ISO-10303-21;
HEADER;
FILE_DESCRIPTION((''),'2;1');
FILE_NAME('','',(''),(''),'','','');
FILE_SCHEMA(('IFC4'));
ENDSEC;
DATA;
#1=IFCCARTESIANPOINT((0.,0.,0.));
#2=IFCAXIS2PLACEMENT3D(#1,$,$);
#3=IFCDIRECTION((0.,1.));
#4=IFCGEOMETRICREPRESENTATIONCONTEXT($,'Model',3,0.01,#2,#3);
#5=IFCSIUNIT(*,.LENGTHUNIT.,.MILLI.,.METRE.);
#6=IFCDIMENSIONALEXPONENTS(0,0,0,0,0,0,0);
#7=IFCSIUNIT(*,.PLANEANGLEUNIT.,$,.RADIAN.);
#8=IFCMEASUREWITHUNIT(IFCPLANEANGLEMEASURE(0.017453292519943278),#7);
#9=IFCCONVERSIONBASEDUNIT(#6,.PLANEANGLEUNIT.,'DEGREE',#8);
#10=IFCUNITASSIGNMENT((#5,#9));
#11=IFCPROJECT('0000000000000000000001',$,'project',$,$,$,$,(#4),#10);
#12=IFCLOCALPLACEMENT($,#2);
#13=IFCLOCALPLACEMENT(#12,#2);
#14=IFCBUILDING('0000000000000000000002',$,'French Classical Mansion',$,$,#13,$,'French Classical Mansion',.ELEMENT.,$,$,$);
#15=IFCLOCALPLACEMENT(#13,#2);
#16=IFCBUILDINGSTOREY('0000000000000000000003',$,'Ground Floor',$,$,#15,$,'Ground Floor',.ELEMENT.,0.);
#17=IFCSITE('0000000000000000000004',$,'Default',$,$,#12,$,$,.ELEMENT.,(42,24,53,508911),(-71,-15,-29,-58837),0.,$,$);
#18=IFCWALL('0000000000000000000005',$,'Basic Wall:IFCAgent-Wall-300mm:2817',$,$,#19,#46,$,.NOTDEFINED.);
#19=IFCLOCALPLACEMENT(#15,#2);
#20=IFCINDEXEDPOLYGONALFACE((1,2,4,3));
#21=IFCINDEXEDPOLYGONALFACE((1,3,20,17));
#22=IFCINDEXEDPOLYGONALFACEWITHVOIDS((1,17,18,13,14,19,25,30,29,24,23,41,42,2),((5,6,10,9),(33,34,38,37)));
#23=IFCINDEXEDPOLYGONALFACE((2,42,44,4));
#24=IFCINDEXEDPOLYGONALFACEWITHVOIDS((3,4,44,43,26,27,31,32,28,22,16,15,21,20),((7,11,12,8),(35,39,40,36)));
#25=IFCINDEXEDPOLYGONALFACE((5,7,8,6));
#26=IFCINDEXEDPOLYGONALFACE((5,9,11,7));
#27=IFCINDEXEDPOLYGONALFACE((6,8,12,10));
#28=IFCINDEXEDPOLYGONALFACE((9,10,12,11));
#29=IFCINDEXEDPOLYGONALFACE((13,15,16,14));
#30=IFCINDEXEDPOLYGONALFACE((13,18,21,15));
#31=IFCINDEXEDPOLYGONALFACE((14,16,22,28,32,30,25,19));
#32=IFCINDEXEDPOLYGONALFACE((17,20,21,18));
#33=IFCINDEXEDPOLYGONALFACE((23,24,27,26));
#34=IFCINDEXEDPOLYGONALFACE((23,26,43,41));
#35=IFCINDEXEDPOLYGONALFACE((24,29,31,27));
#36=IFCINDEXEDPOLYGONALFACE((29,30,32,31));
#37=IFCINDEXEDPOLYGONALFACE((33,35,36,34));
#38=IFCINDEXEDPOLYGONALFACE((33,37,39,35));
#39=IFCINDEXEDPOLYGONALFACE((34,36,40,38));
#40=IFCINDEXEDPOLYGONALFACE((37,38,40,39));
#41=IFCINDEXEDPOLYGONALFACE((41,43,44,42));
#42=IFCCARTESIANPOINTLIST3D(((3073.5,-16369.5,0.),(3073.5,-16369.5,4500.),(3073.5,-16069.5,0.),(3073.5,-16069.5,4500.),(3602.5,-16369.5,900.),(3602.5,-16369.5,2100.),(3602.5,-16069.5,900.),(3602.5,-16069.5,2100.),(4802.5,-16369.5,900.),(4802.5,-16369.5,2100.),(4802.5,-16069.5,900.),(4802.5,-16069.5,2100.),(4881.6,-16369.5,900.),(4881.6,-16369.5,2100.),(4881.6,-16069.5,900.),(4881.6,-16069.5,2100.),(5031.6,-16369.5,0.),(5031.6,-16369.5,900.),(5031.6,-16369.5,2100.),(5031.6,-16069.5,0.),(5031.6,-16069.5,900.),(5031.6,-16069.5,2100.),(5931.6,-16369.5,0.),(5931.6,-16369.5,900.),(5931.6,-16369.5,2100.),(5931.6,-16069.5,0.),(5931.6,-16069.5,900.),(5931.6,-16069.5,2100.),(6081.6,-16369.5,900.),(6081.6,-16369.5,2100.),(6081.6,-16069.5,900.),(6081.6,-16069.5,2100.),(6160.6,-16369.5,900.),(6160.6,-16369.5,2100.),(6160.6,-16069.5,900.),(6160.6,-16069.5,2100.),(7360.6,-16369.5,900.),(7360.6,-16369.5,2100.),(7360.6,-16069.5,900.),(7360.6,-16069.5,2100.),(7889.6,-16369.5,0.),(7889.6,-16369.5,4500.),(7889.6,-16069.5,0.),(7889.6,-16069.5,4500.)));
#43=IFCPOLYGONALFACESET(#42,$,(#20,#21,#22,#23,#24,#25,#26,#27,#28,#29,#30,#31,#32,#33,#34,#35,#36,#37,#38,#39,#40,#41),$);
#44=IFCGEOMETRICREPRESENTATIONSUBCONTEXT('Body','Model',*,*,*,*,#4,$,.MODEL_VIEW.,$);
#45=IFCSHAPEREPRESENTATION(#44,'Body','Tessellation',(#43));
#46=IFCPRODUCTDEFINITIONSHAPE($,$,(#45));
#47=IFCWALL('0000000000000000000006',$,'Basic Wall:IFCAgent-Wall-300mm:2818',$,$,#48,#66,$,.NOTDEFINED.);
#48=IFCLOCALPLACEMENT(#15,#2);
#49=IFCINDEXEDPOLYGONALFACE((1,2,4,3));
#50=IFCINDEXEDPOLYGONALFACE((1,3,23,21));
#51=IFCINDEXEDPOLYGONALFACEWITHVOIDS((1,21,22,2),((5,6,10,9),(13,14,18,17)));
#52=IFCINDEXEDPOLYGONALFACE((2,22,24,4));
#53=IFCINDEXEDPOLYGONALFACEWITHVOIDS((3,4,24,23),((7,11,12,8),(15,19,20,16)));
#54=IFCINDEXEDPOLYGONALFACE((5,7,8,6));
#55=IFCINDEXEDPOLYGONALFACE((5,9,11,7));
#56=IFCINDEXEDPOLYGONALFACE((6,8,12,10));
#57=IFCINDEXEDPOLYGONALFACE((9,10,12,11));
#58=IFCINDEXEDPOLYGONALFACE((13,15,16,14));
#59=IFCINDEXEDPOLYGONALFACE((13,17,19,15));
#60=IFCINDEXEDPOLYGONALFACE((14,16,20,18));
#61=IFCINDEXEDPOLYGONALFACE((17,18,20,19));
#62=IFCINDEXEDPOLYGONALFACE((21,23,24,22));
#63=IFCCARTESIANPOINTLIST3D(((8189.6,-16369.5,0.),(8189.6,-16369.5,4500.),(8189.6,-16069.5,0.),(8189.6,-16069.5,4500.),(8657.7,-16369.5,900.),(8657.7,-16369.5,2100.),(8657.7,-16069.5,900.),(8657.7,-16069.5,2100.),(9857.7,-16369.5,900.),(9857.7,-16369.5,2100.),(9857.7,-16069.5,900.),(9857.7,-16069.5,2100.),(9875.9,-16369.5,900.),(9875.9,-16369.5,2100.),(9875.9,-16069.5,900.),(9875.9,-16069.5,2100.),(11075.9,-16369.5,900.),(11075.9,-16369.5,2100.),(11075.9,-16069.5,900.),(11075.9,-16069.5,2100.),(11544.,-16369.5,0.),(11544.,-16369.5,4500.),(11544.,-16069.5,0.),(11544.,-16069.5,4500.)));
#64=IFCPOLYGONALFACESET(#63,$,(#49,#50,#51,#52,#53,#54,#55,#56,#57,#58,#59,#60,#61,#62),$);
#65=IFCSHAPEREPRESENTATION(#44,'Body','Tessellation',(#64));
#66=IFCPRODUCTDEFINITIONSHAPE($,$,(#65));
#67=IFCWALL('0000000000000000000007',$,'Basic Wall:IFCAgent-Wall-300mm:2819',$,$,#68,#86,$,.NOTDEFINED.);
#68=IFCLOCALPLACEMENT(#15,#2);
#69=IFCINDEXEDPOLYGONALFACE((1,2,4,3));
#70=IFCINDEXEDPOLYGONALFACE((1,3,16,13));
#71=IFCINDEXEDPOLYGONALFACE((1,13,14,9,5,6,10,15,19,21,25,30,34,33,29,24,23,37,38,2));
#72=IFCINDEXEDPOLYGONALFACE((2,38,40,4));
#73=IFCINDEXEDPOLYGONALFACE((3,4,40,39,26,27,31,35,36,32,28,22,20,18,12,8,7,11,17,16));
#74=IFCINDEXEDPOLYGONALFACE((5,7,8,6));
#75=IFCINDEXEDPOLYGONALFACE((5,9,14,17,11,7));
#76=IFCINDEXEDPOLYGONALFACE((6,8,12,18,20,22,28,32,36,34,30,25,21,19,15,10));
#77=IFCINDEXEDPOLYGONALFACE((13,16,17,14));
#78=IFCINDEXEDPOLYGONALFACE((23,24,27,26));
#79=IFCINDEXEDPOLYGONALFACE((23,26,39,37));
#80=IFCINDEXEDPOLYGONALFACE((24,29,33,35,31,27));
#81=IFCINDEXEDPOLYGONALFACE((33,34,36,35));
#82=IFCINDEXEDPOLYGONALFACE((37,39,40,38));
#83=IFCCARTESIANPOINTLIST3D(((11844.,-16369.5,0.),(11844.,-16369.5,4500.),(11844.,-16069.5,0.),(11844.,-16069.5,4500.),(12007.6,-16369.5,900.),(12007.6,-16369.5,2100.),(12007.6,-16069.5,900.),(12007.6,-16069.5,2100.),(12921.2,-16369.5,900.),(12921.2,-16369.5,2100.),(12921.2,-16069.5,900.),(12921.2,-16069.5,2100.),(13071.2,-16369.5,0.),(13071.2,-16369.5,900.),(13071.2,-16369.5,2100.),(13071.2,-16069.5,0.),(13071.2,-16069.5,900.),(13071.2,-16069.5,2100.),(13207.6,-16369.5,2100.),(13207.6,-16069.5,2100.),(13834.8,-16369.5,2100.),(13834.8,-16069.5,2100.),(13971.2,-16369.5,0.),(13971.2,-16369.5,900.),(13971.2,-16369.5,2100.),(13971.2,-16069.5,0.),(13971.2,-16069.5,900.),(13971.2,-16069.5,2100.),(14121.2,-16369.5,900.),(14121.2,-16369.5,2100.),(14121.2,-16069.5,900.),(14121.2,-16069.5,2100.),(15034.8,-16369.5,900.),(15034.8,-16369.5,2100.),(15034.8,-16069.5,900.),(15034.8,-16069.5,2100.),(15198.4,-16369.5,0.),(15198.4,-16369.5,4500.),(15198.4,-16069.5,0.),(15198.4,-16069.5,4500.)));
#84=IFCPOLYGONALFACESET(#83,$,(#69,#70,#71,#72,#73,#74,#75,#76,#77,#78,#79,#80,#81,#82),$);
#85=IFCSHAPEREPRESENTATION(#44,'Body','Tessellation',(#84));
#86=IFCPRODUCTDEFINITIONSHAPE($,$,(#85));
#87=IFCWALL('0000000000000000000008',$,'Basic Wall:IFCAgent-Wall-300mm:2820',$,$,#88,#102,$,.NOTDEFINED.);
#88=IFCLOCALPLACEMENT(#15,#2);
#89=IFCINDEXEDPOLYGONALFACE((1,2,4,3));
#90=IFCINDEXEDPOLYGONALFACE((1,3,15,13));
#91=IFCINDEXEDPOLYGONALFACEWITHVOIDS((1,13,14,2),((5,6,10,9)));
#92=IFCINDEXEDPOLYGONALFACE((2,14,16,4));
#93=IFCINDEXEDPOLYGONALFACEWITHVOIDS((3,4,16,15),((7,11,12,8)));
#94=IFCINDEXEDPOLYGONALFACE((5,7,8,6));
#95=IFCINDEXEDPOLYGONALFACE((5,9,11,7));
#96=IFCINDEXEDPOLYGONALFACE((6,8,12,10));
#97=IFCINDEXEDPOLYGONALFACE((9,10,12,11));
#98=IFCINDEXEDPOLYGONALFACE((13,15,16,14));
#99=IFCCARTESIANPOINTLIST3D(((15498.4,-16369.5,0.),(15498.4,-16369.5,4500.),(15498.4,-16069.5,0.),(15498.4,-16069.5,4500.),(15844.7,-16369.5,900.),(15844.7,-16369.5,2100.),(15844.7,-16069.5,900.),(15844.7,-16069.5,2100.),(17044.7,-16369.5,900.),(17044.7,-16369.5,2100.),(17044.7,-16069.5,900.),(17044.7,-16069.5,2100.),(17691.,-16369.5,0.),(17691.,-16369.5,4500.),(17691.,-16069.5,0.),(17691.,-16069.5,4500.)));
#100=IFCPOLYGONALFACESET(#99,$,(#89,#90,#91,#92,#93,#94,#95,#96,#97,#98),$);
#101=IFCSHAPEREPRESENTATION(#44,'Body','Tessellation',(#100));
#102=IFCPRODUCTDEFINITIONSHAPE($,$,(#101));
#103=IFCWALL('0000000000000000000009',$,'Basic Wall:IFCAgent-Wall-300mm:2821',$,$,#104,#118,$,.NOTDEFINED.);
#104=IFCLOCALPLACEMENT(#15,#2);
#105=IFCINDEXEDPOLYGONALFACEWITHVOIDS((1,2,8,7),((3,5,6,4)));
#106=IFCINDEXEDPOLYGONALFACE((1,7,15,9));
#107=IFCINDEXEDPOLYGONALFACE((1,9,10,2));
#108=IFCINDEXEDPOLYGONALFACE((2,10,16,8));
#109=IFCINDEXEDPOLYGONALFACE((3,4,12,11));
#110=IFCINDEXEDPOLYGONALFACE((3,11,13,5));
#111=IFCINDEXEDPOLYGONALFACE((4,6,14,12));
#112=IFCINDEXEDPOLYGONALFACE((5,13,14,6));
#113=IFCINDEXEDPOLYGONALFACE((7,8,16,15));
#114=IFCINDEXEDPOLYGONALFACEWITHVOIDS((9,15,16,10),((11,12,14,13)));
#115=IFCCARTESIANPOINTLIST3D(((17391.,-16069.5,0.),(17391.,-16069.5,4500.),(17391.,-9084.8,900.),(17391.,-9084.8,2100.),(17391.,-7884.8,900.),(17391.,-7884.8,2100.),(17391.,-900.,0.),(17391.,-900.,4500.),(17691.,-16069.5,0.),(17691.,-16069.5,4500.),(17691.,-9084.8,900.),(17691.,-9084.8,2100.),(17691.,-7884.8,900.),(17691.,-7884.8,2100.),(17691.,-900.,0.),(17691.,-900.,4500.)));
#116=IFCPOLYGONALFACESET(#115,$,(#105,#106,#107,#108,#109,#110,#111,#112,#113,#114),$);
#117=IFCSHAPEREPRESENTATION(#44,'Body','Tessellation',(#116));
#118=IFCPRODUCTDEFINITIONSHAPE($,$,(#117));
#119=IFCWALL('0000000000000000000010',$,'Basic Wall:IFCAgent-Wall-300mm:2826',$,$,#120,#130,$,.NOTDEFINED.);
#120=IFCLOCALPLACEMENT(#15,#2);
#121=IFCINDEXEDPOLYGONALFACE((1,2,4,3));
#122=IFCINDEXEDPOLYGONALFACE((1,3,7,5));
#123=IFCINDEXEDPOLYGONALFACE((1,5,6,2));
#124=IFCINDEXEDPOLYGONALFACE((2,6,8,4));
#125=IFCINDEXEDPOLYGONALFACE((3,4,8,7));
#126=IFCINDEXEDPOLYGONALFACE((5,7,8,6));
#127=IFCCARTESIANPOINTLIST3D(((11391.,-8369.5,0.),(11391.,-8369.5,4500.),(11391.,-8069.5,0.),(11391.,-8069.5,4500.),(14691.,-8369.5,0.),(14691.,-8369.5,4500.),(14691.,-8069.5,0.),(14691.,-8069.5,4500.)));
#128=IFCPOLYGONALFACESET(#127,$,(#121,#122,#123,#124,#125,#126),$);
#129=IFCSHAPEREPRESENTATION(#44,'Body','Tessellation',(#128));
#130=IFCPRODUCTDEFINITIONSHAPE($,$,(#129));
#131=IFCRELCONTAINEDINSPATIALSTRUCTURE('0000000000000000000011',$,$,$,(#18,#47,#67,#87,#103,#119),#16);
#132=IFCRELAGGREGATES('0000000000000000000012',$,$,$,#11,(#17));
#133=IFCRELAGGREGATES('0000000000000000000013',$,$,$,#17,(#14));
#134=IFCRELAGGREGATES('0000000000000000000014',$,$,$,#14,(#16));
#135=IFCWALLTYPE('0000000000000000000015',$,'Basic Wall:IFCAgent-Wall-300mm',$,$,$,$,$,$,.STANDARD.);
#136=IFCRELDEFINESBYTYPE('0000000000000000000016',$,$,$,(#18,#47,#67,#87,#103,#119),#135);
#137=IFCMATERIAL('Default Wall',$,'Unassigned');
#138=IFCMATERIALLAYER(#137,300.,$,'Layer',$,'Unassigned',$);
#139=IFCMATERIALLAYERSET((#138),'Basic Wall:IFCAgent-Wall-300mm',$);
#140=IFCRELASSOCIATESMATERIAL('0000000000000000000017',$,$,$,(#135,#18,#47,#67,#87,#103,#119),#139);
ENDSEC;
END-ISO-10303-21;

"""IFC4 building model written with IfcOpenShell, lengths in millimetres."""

from ifc_helpers import new_model, entity, si_unit, converted_unit, direction, frame, frame_2d, origin, place, context, subcontext, project, spatial, rectangle, extrude, material, layer, layer_set, layer_usage, type_object, element, save


model = new_model("IFC4")

# Units and contexts
model_context = context("Model", 3, precision=0.01, world=origin(), true_north=direction((0.0, 1.0)))
body_context = subcontext(model_context, "Body", "Model", "MODEL_VIEW")
ifc_project = project(units=[si_unit("LENGTHUNIT", "METRE", prefix="MILLI"), converted_unit("PLANEANGLEUNIT", "DEGREE", entity("IfcPlaneAngleMeasure", 0.017453292519943278), si_unit("PLANEANGLEUNIT", "RADIAN"), dimensions=[0, 0, 0, 0, 0, 0, 0])], contexts=[model_context])

# Site, building, storey
site_placement = place(None, origin())
site = spatial("IfcSite", under=ifc_project, at=site_placement, Name="Default", CompositionType="ELEMENT", RefLatitude=(42, 24, 53, 508911), RefLongitude=(-71, -15, -29, -58837), RefElevation=0.0)
building_placement = place(site_placement, origin())
building = spatial("IfcBuilding", under=site, at=building_placement, Name="French Classical Mansion", LongName="French Classical Mansion", CompositionType="ELEMENT")
storey_placement = place(building_placement, origin())
storey = spatial("IfcBuildingStorey", under=building, at=storey_placement, Name="Ground Floor", LongName="Ground Floor", CompositionType="ELEMENT", Elevation=0.0)

# Shared definitions
ifc_material = material(Name="Default Wall", Category="Unassigned")
ifc_layer = layer(ifc_material, 300.0, Name="Layer", Category="Unassigned")
ifc_layer_set = layer_set([ifc_layer], Name="Basic Wall:IFCAgent-Wall-300mm")
wall_type = type_object("IfcWallType", Name="Basic Wall:IFCAgent-Wall-300mm", PredefinedType="STANDARD", material=ifc_layer_set)

# Walls, openings
ifc_layer_usage_1 = layer_usage(ifc_layer_set, "AXIS2", "NEGATIVE", 150.0)
wall_1_placement = place(storey_placement, frame((3073.5, -16219.5, 0.0)))
wall_1 = element("IfcWall", 1, at=wall_1_placement, inside=storey, type_object=wall_type, material=ifc_layer_usage_1, Name="Basic Wall:IFCAgent-Wall-300mm:2817", PredefinedType="NOTDEFINED", context=body_context, shape_type="SweptSolid", body=[
    extrude(rectangle(XDim=4816.1, YDim=300.0, at=frame_2d((2408.1, 0.0), x_axis=(-1.0, 0.0))), origin(), (0.0, 0.0, 1.0), 4500.0),
])
opening_1_placement = place(wall_1_placement, origin())
element("IfcOpeningElement", 2, at=opening_1_placement, cuts=wall_1, PredefinedType="OPENING", context=body_context, shape_type="SweptSolid", body=[
    extrude(rectangle(XDim=2100.0, YDim=900.0, at=frame_2d((0.0, 0.0), x_axis=(1.0, 0.0))), frame((2408.1, -150.0, 1050.0), z_axis=(0.0, 1.0, 0.0), x_axis=(0.0, 0.0, -1.0)), (0.0, 0.0, 1.0), 300.0),
])
opening_2_placement = place(wall_1_placement, origin())
element("IfcOpeningElement", 3, at=opening_2_placement, cuts=wall_1, PredefinedType="OPENING", context=body_context, shape_type="SweptSolid", body=[
    extrude(rectangle(XDim=2100.0, YDim=900.0, at=frame_2d((0.0, 0.0), x_axis=(1.0, 0.0))), frame((2408.1, -150.0, 1050.0), z_axis=(0.0, 1.0, 0.0), x_axis=(0.0, 0.0, -1.0)), (0.0, 0.0, 1.0), 300.0),
])
opening_3_placement = place(wall_1_placement, origin())
element("IfcOpeningElement", 4, at=opening_3_placement, cuts=wall_1, PredefinedType="OPENING", context=body_context, shape_type="SweptSolid", body=[
    extrude(rectangle(XDim=1200.0, YDim=1200.0, at=frame_2d((0.0, 0.0), x_axis=(1.0, 0.0))), frame((1129.0, -150.0, 1500.0), z_axis=(0.0, 1.0, 0.0), x_axis=(0.0, 0.0, -1.0)), (0.0, 0.0, 1.0), 300.0),
])
opening_4_placement = place(wall_1_placement, origin())
element("IfcOpeningElement", 5, at=opening_4_placement, cuts=wall_1, PredefinedType="OPENING", context=body_context, shape_type="SweptSolid", body=[
    extrude(rectangle(XDim=1200.0, YDim=1200.0, at=frame_2d((0.0, 0.0), x_axis=(1.0, 0.0))), frame((2408.1, -150.0, 1500.0), z_axis=(0.0, 1.0, 0.0), x_axis=(0.0, 0.0, -1.0)), (0.0, 0.0, 1.0), 300.0),
])
opening_5_placement = place(wall_1_placement, origin())
element("IfcOpeningElement", 6, at=opening_5_placement, cuts=wall_1, PredefinedType="OPENING", context=body_context, shape_type="SweptSolid", body=[
    extrude(rectangle(XDim=1200.0, YDim=1200.0, at=frame_2d((0.0, 0.0), x_axis=(1.0, 0.0))), frame((3687.1, -150.0, 1500.0), z_axis=(0.0, 1.0, 0.0), x_axis=(0.0, 0.0, -1.0)), (0.0, 0.0, 1.0), 300.0),
])
ifc_layer_usage_2 = layer_usage(ifc_layer_set, "AXIS2", "NEGATIVE", 150.0)
wall_2_placement = place(storey_placement, frame((8189.6, -16219.5, 0.0)))
wall_2 = element("IfcWall", 7, at=wall_2_placement, inside=storey, type_object=wall_type, material=ifc_layer_usage_2, Name="Basic Wall:IFCAgent-Wall-300mm:2818", PredefinedType="NOTDEFINED", context=body_context, shape_type="SweptSolid", body=[
    extrude(rectangle(XDim=3354.4, YDim=300.0, at=frame_2d((1677.2, 0.0), x_axis=(-1.0, 0.0))), origin(), (0.0, 0.0, 1.0), 4500.0),
])
opening_6_placement = place(wall_2_placement, origin())
element("IfcOpeningElement", 8, at=opening_6_placement, cuts=wall_2, PredefinedType="OPENING", context=body_context, shape_type="SweptSolid", body=[
    extrude(rectangle(XDim=1200.0, YDim=1200.0, at=frame_2d((0.0, 0.0), x_axis=(1.0, 0.0))), frame((1068.1, -150.0, 1500.0), z_axis=(0.0, 1.0, 0.0), x_axis=(0.0, 0.0, -1.0)), (0.0, 0.0, 1.0), 300.0),
])
opening_7_placement = place(wall_2_placement, origin())
element("IfcOpeningElement", 9, at=opening_7_placement, cuts=wall_2, PredefinedType="OPENING", context=body_context, shape_type="SweptSolid", body=[
    extrude(rectangle(XDim=1200.0, YDim=1200.0, at=frame_2d((0.0, 0.0), x_axis=(1.0, 0.0))), frame((2286.2, -150.0, 1500.0), z_axis=(0.0, 1.0, 0.0), x_axis=(0.0, 0.0, -1.0)), (0.0, 0.0, 1.0), 300.0),
])
ifc_layer_usage_3 = layer_usage(ifc_layer_set, "AXIS2", "NEGATIVE", 150.0)
wall_3_placement = place(storey_placement, frame((11844.0, -16219.5, 0.0)))
wall_3 = element("IfcWall", 10, at=wall_3_placement, inside=storey, type_object=wall_type, material=ifc_layer_usage_3, Name="Basic Wall:IFCAgent-Wall-300mm:2819", PredefinedType="NOTDEFINED", context=body_context, shape_type="SweptSolid", body=[
    extrude(rectangle(XDim=3354.4, YDim=300.0, at=frame_2d((1677.2, 0.0), x_axis=(-1.0, 0.0))), origin(), (0.0, 0.0, 1.0), 4500.0),
])
opening_8_placement = place(wall_3_placement, origin())
element("IfcOpeningElement", 11, at=opening_8_placement, cuts=wall_3, PredefinedType="OPENING", context=body_context, shape_type="SweptSolid", body=[
    extrude(rectangle(XDim=2100.0, YDim=900.0, at=frame_2d((0.0, 0.0), x_axis=(1.0, 0.0))), frame((1677.2, -150.0, 1050.0), z_axis=(0.0, 1.0, 0.0), x_axis=(0.0, 0.0, -1.0)), (0.0, 0.0, 1.0), 300.0),
])
opening_9_placement = place(wall_3_placement, origin())
element("IfcOpeningElement", 12, at=opening_9_placement, cuts=wall_3, PredefinedType="OPENING", context=body_context, shape_type="SweptSolid", body=[
    extrude(rectangle(XDim=1200.0, YDim=1200.0, at=frame_2d((0.0, 0.0), x_axis=(1.0, 0.0))), frame((763.6, -150.0, 1500.0), z_axis=(0.0, 1.0, 0.0), x_axis=(0.0, 0.0, -1.0)), (0.0, 0.0, 1.0), 300.0),
])
opening_10_placement = place(wall_3_placement, origin())
element("IfcOpeningElement", 13, at=opening_10_placement, cuts=wall_3, PredefinedType="OPENING", context=body_context, shape_type="SweptSolid", body=[
    extrude(rectangle(XDim=1200.0, YDim=1200.0, at=frame_2d((0.0, 0.0), x_axis=(1.0, 0.0))), frame((1677.2, -150.0, 1500.0), z_axis=(0.0, 1.0, 0.0), x_axis=(0.0, 0.0, -1.0)), (0.0, 0.0, 1.0), 300.0),
])
opening_11_placement = place(wall_3_placement, origin())
element("IfcOpeningElement", 14, at=opening_11_placement, cuts=wall_3, PredefinedType="OPENING", context=body_context, shape_type="SweptSolid", body=[
    extrude(rectangle(XDim=1200.0, YDim=1200.0, at=frame_2d((0.0, 0.0), x_axis=(1.0, 0.0))), frame((2590.8, -150.0, 1500.0), z_axis=(0.0, 1.0, 0.0), x_axis=(0.0, 0.0, -1.0)), (0.0, 0.0, 1.0), 300.0),
])

# Walls, openings
ifc_layer_usage_4 = layer_usage(ifc_layer_set, "AXIS2", "NEGATIVE", 150.0)
wall_4_placement = place(storey_placement, frame((15498.4, -16219.5, 0.0)))
wall_4 = element("IfcWall", 15, at=wall_4_placement, inside=storey, type_object=wall_type, material=ifc_layer_usage_4, Name="Basic Wall:IFCAgent-Wall-300mm:2820", PredefinedType="NOTDEFINED", context=body_context, shape_type="SweptSolid", body=[
    extrude(rectangle(XDim=2192.6, YDim=300.0, at=frame_2d((1096.3, 0.0), x_axis=(-1.0, 0.0))), origin(), (0.0, 0.0, 1.0), 4500.0),
])
opening_12_placement = place(wall_4_placement, origin())
element("IfcOpeningElement", 16, at=opening_12_placement, cuts=wall_4, PredefinedType="OPENING", context=body_context, shape_type="SweptSolid", body=[
    extrude(rectangle(XDim=1200.0, YDim=1200.0, at=frame_2d((0.0, 0.0), x_axis=(1.0, 0.0))), frame((946.3, -150.0, 1500.0), z_axis=(0.0, 1.0, 0.0), x_axis=(0.0, 0.0, -1.0)), (0.0, 0.0, 1.0), 300.0),
])
ifc_layer_usage_5 = layer_usage(ifc_layer_set, "AXIS2", "NEGATIVE", 150.0)
wall_5_placement = place(storey_placement, frame((17541.0, -16069.5, 0.0), z_axis=(0.0, 0.0, 1.0), x_axis=(0.0, 1.0, 0.0)))
wall_5 = element("IfcWall", 17, at=wall_5_placement, inside=storey, type_object=wall_type, material=ifc_layer_usage_5, Name="Basic Wall:IFCAgent-Wall-300mm:2821", PredefinedType="NOTDEFINED", context=body_context, shape_type="SweptSolid", body=[
    extrude(rectangle(XDim=15169.5, YDim=300.0, at=frame_2d((7584.8, 0.0), x_axis=(-1.0, 0.0))), origin(), (0.0, 0.0, 1.0), 4500.0),
])
opening_13_placement = place(wall_5_placement, origin())
element("IfcOpeningElement", 18, at=opening_13_placement, cuts=wall_5, PredefinedType="OPENING", context=body_context, shape_type="SweptSolid", body=[
    extrude(rectangle(XDim=1200.0, YDim=1200.0, at=frame_2d((0.0, 0.0), x_axis=(1.0, 0.0))), frame((7584.8, -150.0, 1500.0), z_axis=(0.0, 1.0, 0.0), x_axis=(0.0, 0.0, -1.0)), (0.0, 0.0, 1.0), 300.0),
])

# Wall
ifc_layer_usage_6 = layer_usage(ifc_layer_set, "AXIS2", "NEGATIVE", 150.0)
wall_6_placement = place(storey_placement, frame((11391.0, -8219.5, 0.0)))
element("IfcWall", 19, at=wall_6_placement, inside=storey, type_object=wall_type, material=ifc_layer_usage_6, Name="Basic Wall:IFCAgent-Wall-300mm:2826", PredefinedType="NOTDEFINED", context=body_context, shape_type="SweptSolid", body=[
    extrude(rectangle(XDim=3300.0, YDim=300.0, at=frame_2d((1650.0, 0.0), x_axis=(-1.0, 0.0))), origin(), (0.0, 0.0, 1.0), 4500.0),
])

save(model, "model.ifc")
